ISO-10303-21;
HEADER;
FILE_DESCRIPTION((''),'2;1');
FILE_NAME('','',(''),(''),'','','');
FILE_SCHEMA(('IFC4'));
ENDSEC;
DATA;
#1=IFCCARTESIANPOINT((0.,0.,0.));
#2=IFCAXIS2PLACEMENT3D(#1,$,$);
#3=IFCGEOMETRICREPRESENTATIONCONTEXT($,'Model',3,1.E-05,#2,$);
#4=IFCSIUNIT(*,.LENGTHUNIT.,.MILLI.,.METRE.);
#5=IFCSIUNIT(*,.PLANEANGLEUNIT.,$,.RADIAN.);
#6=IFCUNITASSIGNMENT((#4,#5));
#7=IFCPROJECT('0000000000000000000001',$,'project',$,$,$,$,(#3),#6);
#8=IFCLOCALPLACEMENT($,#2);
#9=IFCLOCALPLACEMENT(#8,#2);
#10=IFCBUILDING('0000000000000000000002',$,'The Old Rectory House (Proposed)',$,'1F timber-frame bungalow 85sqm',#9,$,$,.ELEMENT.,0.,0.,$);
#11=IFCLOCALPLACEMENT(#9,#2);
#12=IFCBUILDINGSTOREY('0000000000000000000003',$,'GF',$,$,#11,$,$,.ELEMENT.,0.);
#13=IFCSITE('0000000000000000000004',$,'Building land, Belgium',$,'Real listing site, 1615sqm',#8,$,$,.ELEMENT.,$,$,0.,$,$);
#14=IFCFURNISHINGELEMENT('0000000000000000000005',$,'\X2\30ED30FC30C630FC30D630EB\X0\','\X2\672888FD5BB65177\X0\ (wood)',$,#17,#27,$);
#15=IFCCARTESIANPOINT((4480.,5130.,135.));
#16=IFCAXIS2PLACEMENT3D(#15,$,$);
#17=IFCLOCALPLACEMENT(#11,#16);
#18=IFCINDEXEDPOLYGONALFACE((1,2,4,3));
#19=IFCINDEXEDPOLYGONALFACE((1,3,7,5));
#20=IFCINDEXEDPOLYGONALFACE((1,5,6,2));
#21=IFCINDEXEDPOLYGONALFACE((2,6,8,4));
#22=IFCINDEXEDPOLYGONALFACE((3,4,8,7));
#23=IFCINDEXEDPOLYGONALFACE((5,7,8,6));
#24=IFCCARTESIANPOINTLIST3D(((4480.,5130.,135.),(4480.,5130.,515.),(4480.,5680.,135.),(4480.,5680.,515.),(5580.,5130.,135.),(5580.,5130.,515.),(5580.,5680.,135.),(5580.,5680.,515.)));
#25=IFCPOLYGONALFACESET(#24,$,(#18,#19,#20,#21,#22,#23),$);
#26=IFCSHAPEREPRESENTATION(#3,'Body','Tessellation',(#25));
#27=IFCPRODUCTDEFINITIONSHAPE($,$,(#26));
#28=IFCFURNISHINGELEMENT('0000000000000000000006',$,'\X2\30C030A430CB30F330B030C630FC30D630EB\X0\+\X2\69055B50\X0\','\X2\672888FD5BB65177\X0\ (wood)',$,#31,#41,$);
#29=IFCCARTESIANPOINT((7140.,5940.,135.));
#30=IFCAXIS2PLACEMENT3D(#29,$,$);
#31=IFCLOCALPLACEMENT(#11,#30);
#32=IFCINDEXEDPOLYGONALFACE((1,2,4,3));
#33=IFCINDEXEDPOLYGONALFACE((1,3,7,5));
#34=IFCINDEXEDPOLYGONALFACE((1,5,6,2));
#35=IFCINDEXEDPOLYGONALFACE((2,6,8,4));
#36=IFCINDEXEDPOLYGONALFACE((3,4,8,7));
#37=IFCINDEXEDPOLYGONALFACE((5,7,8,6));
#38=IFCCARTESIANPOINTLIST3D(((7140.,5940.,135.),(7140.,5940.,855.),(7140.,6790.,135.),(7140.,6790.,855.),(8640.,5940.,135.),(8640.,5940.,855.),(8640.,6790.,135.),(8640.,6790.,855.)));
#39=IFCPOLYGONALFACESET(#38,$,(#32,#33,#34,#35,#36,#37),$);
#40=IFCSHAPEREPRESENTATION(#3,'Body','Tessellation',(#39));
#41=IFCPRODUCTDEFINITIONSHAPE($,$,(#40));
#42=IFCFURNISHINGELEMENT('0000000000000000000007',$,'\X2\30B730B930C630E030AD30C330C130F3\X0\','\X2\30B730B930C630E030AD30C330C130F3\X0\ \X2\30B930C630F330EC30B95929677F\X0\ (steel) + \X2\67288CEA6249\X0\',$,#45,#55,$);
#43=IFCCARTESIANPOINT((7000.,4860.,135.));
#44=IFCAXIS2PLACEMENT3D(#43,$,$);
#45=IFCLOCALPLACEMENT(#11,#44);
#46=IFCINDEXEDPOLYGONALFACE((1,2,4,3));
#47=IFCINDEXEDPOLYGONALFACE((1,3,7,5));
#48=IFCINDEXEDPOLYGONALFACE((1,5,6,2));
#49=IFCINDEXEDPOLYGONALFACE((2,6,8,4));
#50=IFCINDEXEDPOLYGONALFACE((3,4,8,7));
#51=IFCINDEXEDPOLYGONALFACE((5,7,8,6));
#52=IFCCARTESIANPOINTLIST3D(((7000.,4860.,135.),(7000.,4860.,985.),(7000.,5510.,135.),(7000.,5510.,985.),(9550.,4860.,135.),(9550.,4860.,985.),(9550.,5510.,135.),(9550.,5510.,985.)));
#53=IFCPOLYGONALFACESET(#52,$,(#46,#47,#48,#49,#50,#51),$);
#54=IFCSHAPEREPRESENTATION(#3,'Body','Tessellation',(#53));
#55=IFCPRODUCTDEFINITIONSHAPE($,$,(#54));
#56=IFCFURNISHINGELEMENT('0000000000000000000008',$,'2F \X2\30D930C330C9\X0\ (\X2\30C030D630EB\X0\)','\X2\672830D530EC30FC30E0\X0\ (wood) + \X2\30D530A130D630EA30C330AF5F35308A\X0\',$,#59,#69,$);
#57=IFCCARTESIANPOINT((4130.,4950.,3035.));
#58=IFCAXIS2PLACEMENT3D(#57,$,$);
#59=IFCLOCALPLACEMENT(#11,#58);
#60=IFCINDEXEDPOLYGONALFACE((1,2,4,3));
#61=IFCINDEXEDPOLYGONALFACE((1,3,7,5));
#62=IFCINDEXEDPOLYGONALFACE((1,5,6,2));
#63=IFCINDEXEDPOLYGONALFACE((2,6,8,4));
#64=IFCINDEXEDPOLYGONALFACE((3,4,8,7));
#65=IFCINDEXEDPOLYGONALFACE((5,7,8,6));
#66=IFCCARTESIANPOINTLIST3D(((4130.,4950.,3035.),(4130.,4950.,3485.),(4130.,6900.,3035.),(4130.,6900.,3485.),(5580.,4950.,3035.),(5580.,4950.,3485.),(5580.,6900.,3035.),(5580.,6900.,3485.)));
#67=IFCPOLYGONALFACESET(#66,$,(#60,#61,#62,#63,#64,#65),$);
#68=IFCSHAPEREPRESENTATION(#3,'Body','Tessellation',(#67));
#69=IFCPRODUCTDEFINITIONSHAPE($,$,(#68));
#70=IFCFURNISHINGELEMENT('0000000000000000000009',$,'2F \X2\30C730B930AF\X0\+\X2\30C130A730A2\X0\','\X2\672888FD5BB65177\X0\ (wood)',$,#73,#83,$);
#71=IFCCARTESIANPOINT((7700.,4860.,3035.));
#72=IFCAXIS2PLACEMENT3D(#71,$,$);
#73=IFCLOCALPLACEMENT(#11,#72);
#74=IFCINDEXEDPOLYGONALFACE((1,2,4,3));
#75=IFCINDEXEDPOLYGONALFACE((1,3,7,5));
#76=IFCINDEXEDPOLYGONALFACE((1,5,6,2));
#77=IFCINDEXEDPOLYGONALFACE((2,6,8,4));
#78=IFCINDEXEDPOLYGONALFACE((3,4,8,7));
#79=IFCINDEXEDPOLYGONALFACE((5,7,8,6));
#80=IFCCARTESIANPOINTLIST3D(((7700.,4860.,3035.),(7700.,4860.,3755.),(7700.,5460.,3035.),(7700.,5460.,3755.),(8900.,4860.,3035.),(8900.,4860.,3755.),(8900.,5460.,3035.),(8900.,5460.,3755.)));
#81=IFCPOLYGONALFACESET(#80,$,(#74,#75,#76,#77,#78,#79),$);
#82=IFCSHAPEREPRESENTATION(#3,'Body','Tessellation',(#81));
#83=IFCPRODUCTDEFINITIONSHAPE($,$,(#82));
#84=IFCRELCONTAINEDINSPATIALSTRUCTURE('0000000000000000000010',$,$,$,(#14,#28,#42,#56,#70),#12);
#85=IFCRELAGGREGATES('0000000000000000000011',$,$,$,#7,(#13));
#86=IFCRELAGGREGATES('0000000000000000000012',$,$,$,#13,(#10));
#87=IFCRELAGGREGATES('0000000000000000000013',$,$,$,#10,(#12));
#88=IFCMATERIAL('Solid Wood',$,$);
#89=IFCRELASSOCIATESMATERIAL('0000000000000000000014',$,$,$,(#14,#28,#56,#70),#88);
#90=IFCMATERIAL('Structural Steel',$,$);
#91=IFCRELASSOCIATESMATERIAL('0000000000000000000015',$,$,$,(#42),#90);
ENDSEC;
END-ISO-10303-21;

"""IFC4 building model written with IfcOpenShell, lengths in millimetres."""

from ifc_helpers import new_model, si_unit, frame, frame_2d, origin, place, context, project, spatial, rectangle, extrude, material, element, save


model = new_model("IFC4")

# Units and contexts
model_context = context("Model", 3, precision=1e-05, world=origin())
ifc_project = project(units=[si_unit("LENGTHUNIT", "METRE", prefix="MILLI"), si_unit("PLANEANGLEUNIT", "RADIAN")], contexts=[model_context])

# Site, building, storey
site_placement = place(None, origin())
site = spatial("IfcSite", under=ifc_project, at=site_placement, Name="Building land, Belgium", ObjectType="Real listing site, 1615sqm", CompositionType="ELEMENT", RefElevation=0.0)
building_placement = place(site_placement, origin())
building = spatial("IfcBuilding", under=site, at=building_placement, Name="The Old Rectory House (Proposed)", ObjectType="1F timber-frame bungalow 85sqm", CompositionType="ELEMENT", ElevationOfRefHeight=0.0, ElevationOfTerrain=0.0)
storey_placement = place(building_placement, origin())
storey = spatial("IfcBuildingStorey", under=building, at=storey_placement, Name="GF", CompositionType="ELEMENT", Elevation=0.0)

# Shared definitions
ifc_material_1 = material(Name="Solid Wood")

# Shared definitions
ifc_material_2 = material(Name="Structural Steel")

# Furnishing elements
furnishing_1_placement = place(storey_placement, frame((4480.0, 5130.0, 135.0)))
element("IfcFurnishingElement", 1, at=furnishing_1_placement, inside=storey, material=ifc_material_1, Name="ローテーブル", Description="木製家具 (wood)", context=model_context, shape_type="SweptSolid", body=[
    extrude(rectangle(XDim=1100.0, YDim=550.0, at=frame_2d((550.0, 275.0))), frame((4480.0, 5130.0, 135.0)), (0.0, 0.0, 1.0), 380.0),
])
furnishing_2_placement = place(storey_placement, frame((7140.0, 5940.0, 135.0)))
element("IfcFurnishingElement", 2, at=furnishing_2_placement, inside=storey, material=ifc_material_1, Name="ダイニングテーブル+椅子", Description="木製家具 (wood)", context=model_context, shape_type="SweptSolid", body=[
    extrude(rectangle(XDim=1500.0, YDim=850.0, at=frame_2d((750.0, 425.0))), frame((7140.0, 5940.0, 135.0)), (0.0, 0.0, 1.0), 720.0),
])
furnishing_3_placement = place(storey_placement, frame((7000.0, 4860.0, 135.0)))
element("IfcFurnishingElement", 3, at=furnishing_3_placement, inside=storey, material=ifc_material_2, Name="システムキッチン", Description="システムキッチン ステンレス天板 (steel) + 木質扉", context=model_context, shape_type="SweptSolid", body=[
    extrude(rectangle(XDim=2550.0, YDim=650.0, at=frame_2d((1275.0, 325.0))), frame((7000.0, 4860.0, 135.0)), (0.0, 0.0, 1.0), 850.0),
])
furnishing_4_placement = place(storey_placement, frame((4130.0, 4950.0, 3035.0)))
element("IfcFurnishingElement", 4, at=furnishing_4_placement, inside=storey, material=ifc_material_1, Name="2F ベッド (ダブル)", Description="木フレーム (wood) + ファブリック張り", context=model_context, shape_type="SweptSolid", body=[
    extrude(rectangle(XDim=1450.0, YDim=1950.0, at=frame_2d((725.0, 975.0))), frame((4130.0, 4950.0, 3035.0)), (0.0, 0.0, 1.0), 450.0),
])
furnishing_5_placement = place(storey_placement, frame((7700.0, 4860.0, 3035.0)))
element("IfcFurnishingElement", 5, at=furnishing_5_placement, inside=storey, material=ifc_material_1, Name="2F デスク+チェア", Description="木製家具 (wood)", context=model_context, shape_type="SweptSolid", body=[
    extrude(rectangle(XDim=1200.0, YDim=600.0, at=frame_2d((600.0, 300.0))), frame((7700.0, 4860.0, 3035.0)), (0.0, 0.0, 1.0), 720.0),
])

save(model, "model.ifc")
